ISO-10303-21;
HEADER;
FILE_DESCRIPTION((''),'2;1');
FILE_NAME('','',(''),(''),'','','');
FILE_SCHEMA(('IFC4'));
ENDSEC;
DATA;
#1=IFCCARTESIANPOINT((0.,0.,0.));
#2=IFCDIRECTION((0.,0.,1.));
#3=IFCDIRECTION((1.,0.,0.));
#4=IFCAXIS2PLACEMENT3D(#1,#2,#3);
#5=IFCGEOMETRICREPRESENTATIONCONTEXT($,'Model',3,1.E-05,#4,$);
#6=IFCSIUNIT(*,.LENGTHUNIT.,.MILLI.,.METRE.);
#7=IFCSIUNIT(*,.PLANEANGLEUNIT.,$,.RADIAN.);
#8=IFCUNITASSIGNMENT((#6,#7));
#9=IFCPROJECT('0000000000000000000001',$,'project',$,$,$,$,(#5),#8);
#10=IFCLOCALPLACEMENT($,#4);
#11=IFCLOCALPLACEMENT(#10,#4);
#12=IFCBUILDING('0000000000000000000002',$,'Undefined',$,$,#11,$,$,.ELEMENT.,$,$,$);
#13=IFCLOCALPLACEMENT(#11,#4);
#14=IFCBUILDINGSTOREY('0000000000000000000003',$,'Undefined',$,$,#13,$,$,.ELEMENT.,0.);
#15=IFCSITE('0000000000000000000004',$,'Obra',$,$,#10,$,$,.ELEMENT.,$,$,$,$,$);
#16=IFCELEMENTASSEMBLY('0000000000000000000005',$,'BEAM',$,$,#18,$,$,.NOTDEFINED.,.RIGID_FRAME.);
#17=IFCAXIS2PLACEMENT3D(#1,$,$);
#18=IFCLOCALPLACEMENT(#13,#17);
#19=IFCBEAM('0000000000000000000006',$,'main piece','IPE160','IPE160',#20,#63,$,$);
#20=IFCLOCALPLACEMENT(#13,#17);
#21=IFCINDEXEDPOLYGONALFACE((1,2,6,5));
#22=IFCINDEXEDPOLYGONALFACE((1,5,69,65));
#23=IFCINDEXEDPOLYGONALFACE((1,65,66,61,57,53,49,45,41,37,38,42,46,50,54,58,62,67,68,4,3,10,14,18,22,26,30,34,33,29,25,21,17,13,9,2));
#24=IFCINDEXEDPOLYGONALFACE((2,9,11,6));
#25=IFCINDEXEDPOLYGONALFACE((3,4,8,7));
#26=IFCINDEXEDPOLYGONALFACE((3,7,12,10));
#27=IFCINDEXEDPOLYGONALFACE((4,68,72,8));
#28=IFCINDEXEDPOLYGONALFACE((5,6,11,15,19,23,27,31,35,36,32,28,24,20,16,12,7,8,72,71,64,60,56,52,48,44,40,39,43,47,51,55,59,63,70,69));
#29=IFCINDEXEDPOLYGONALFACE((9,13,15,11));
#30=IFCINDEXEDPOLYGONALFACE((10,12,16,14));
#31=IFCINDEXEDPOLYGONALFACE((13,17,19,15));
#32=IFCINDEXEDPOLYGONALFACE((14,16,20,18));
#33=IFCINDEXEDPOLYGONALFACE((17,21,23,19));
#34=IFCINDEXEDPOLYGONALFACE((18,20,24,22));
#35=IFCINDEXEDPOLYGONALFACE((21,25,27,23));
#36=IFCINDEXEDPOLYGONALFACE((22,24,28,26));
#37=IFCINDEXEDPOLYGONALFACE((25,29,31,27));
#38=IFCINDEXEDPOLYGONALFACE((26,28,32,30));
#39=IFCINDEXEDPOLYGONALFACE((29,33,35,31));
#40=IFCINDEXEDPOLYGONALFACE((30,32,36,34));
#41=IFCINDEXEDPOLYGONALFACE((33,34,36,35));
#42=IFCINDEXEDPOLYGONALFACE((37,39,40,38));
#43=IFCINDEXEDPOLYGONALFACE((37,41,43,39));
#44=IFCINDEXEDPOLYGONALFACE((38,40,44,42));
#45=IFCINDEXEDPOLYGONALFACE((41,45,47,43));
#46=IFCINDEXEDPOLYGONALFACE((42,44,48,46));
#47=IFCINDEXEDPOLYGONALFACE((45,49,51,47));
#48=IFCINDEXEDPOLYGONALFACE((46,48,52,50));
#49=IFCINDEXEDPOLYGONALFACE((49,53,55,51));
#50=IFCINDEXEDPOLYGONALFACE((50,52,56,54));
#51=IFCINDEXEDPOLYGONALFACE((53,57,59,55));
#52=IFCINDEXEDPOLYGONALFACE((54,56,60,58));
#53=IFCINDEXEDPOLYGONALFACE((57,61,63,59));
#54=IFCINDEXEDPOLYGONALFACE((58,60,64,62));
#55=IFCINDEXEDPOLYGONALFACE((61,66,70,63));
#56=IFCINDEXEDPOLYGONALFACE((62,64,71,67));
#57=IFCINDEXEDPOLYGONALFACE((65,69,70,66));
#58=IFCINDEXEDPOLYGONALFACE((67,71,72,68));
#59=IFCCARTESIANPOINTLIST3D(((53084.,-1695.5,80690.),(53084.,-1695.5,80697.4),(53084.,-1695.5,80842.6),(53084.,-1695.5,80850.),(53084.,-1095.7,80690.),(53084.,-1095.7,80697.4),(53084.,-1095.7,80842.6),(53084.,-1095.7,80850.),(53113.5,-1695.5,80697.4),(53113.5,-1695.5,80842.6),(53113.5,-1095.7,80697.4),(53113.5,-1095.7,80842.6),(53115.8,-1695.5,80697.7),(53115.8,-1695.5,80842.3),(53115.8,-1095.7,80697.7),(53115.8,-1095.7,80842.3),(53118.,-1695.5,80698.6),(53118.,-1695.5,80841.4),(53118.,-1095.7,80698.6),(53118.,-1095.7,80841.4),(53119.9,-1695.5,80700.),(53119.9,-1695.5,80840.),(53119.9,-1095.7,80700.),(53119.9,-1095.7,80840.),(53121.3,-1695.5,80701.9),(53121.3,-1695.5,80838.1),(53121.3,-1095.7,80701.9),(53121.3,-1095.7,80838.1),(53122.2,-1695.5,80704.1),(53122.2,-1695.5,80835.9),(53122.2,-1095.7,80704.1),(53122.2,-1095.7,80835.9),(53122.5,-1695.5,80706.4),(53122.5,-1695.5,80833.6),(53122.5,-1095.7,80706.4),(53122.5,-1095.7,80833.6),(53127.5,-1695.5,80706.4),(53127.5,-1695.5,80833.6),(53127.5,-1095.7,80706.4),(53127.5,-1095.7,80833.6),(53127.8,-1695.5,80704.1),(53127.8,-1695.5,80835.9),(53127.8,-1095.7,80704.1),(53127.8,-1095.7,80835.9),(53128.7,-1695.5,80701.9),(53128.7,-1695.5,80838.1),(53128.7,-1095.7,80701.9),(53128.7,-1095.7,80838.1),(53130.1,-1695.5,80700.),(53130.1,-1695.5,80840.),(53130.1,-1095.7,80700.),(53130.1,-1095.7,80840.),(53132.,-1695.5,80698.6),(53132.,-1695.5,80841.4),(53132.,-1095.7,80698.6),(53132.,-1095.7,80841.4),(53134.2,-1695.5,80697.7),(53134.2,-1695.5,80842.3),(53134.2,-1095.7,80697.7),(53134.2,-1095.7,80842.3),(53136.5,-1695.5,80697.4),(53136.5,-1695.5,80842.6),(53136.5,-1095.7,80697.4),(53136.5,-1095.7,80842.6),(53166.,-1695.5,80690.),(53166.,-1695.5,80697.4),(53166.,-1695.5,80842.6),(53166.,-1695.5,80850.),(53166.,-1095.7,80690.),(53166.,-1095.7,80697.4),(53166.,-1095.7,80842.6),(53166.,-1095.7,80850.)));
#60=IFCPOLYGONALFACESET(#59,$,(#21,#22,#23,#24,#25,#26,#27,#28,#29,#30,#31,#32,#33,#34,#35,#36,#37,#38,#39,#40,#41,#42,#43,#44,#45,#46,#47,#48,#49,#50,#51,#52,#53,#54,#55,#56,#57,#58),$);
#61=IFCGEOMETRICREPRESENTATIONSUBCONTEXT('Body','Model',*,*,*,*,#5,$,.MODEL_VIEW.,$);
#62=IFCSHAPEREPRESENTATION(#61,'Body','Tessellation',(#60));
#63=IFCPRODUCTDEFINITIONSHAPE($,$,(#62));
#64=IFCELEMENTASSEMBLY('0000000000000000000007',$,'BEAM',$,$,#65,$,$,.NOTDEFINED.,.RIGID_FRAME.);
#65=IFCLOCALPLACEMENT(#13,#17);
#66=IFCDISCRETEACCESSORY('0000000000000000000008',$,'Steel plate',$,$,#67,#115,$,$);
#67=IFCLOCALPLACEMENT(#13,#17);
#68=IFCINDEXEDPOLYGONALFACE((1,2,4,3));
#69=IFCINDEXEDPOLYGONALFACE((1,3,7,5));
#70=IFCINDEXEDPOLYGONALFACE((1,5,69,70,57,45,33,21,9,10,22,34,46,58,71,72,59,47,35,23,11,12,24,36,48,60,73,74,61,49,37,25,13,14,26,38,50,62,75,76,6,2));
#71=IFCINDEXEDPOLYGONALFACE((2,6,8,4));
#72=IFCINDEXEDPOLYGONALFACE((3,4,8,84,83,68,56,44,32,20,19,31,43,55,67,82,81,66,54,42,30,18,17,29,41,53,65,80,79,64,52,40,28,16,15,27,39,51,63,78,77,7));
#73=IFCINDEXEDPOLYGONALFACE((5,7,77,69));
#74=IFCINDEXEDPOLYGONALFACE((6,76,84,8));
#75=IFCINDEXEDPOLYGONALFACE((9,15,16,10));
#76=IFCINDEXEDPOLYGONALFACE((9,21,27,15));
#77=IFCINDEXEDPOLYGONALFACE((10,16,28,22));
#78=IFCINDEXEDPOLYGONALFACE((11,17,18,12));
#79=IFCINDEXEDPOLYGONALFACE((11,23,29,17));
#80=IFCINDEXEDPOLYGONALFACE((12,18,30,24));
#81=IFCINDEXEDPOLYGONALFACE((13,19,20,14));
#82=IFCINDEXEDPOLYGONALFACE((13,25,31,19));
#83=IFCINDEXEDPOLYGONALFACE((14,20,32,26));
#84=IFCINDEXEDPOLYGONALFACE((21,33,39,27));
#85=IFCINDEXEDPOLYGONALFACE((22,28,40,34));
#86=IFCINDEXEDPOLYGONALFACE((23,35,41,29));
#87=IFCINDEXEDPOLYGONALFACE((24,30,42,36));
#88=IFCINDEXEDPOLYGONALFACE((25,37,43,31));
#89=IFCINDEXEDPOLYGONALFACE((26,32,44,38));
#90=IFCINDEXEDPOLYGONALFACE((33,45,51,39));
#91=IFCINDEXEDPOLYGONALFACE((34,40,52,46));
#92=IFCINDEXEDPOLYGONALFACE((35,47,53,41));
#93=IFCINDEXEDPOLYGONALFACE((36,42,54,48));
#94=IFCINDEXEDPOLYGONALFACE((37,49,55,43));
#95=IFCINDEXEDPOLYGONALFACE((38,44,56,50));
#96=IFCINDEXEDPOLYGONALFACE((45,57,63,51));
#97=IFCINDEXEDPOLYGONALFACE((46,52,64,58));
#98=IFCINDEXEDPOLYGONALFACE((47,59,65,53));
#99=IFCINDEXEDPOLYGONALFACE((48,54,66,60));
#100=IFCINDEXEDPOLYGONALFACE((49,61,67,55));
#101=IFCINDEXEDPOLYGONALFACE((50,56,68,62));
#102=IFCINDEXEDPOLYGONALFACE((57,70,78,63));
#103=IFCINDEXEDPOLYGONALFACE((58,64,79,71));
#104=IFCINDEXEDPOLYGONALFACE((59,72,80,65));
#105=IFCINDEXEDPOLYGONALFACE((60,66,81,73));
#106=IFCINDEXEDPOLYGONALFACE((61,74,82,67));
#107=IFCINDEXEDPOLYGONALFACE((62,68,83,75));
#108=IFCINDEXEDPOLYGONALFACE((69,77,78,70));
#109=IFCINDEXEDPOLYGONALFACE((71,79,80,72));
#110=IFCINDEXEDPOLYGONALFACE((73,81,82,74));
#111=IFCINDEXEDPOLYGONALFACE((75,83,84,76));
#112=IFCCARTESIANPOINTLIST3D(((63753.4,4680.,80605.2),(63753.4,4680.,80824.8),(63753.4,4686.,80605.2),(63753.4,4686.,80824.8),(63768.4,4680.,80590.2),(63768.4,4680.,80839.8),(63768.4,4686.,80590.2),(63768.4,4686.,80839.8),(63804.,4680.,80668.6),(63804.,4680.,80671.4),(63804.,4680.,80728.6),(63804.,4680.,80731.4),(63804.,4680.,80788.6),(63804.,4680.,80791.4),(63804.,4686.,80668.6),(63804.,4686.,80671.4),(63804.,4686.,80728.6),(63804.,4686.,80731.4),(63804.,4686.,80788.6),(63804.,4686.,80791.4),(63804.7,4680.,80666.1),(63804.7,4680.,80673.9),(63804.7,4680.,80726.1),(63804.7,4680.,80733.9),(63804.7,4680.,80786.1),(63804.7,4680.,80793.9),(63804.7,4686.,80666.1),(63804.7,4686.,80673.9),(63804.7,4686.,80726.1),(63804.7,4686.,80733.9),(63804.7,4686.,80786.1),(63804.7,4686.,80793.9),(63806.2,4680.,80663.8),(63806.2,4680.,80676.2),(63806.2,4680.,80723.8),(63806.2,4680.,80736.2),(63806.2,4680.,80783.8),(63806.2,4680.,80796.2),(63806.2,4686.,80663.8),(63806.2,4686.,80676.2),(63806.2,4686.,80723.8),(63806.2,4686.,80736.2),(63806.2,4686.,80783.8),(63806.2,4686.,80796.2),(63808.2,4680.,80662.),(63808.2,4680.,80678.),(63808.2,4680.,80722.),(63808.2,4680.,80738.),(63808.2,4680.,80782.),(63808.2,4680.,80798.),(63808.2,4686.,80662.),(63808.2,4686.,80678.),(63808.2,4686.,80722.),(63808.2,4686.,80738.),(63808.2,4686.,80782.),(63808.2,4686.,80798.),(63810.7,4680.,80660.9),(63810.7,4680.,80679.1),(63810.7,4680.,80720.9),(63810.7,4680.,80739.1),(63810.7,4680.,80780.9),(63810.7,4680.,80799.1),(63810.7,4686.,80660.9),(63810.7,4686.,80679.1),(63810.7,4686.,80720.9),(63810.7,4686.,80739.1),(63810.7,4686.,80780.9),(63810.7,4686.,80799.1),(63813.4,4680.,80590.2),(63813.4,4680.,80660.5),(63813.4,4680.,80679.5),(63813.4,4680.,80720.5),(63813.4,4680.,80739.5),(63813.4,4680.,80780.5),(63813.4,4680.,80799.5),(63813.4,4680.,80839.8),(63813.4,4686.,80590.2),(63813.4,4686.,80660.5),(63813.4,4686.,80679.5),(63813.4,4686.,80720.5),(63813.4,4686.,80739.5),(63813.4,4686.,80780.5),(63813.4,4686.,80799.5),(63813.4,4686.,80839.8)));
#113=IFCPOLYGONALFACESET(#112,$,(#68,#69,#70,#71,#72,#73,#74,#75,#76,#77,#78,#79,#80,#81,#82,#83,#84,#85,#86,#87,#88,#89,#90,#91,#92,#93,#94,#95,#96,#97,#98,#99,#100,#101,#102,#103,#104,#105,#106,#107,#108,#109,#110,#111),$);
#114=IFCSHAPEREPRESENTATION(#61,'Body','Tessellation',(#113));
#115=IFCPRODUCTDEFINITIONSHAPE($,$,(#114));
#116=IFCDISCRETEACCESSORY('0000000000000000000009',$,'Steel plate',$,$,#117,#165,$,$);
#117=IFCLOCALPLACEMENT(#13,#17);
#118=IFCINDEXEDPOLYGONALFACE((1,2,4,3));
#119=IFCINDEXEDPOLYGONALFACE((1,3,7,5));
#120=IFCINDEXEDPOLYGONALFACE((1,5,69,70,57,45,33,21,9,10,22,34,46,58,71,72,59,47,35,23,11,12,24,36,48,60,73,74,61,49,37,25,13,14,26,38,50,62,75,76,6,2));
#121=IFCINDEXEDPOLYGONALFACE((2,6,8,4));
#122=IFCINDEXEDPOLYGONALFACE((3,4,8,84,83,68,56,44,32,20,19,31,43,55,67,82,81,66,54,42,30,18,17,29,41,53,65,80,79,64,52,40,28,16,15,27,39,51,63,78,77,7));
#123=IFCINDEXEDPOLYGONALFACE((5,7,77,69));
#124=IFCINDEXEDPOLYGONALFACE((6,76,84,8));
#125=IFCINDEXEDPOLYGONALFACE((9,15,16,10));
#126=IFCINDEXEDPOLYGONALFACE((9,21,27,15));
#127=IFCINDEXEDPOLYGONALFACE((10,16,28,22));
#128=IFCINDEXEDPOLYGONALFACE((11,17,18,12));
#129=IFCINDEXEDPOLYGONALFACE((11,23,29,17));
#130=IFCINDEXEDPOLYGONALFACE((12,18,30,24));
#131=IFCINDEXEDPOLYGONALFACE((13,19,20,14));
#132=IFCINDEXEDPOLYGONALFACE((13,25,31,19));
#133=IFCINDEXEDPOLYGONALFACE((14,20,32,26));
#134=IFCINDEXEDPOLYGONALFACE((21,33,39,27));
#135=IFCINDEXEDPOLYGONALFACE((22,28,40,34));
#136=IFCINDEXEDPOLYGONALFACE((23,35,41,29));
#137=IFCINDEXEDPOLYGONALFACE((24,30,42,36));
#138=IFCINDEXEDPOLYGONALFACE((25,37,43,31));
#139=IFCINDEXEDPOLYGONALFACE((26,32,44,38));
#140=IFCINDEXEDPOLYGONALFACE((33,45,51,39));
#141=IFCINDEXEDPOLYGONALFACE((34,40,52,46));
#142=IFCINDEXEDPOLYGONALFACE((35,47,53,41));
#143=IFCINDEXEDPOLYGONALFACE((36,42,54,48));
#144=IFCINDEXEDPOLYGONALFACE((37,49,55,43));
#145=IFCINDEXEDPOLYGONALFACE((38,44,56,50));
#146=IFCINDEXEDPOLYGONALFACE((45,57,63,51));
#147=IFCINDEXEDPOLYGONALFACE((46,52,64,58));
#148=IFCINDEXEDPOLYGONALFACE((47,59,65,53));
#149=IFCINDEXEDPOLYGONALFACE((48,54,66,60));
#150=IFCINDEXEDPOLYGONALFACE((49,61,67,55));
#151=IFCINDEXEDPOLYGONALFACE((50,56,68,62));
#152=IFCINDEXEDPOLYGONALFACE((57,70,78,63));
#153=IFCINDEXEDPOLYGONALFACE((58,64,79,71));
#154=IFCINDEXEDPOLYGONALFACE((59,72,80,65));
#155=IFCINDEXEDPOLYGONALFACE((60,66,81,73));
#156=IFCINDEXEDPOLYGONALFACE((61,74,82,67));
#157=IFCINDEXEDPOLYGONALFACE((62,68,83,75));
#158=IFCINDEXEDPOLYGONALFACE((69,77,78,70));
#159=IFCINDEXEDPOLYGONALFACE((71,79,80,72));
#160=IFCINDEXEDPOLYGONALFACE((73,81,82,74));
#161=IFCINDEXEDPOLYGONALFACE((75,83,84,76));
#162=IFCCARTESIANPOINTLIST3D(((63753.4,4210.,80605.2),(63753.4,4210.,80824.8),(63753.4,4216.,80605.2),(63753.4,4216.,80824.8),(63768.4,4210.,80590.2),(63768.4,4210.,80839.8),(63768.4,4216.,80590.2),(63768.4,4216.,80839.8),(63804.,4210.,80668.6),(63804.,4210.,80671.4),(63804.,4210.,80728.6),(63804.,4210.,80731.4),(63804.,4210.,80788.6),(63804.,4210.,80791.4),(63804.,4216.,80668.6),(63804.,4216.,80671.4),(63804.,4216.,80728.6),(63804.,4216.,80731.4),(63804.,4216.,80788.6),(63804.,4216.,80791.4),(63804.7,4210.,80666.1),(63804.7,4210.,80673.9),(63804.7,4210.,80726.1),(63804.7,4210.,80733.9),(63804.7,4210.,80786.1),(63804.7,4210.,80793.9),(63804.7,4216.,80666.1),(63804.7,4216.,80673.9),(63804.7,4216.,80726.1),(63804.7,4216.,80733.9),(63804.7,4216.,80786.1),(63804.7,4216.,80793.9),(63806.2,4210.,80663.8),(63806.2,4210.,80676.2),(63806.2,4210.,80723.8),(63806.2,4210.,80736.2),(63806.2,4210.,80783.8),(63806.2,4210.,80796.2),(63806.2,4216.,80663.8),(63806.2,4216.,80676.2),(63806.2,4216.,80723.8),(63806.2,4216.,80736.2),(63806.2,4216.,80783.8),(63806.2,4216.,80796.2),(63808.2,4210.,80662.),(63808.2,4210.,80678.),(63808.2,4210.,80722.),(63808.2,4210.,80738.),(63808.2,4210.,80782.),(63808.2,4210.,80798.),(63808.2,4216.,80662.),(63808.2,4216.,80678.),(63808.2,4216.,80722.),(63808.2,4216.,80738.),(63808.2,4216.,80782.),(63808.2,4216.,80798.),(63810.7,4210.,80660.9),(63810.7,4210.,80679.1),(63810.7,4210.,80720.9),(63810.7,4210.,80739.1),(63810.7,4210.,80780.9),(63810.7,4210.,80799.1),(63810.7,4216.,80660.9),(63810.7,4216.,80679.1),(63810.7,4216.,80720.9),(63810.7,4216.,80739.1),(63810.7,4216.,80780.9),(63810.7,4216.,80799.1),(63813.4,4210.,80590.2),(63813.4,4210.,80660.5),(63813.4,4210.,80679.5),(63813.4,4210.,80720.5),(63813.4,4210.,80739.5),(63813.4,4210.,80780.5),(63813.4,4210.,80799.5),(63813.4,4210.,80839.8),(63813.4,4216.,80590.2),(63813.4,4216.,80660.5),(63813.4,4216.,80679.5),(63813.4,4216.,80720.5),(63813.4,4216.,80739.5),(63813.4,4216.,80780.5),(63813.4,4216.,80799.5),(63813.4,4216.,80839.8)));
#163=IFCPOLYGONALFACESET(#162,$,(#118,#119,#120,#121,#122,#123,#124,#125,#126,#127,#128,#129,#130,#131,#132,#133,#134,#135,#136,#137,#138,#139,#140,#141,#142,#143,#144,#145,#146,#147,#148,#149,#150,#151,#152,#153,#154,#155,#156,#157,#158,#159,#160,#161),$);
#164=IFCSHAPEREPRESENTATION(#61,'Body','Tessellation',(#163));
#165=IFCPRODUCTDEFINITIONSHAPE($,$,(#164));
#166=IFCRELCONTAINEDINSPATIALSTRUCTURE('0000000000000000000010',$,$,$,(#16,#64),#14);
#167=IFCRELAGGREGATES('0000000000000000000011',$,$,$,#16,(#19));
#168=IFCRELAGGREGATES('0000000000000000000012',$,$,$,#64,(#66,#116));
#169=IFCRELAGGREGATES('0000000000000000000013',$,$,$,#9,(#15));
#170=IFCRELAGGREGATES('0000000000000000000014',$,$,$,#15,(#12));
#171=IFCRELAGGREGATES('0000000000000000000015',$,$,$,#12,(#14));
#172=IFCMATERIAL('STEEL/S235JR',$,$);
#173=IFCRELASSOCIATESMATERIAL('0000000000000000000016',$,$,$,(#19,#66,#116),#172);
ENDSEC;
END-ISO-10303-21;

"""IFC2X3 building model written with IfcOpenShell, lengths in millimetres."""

from ifc_helpers import new_model, si_unit, frame, origin_with_axes, origin_2d_with_axis, place, context, subcontext, project, spatial, polyline, circle, i_section, outline, extrude, source, transform, mapped, material, element, aggregate, save


model = new_model("IFC2X3")

# Units and contexts
model_context = context("Model", 3, precision=1e-05, world=origin_with_axes())
body_context = subcontext(model_context, "Body", "Model", "MODEL_VIEW")
ifc_project = project(units=[si_unit("LENGTHUNIT", "METRE", prefix="MILLI"), si_unit("PLANEANGLEUNIT", "RADIAN")], contexts=[model_context])

# Site, building, storey
site_placement = place(None, origin_with_axes())
site = spatial("IfcSite", under=ifc_project, at=site_placement, Name="Obra", CompositionType="ELEMENT")
building_placement = place(site_placement, origin_with_axes())
building = spatial("IfcBuilding", under=site, at=building_placement, Name="Undefined", CompositionType="ELEMENT")
storey_placement = place(building_placement, origin_with_axes())
storey = spatial("IfcBuildingStorey", under=building, at=storey_placement, Name="Undefined", CompositionType="ELEMENT", Elevation=0.0)

# Element assembly, beam
ifc_material_1 = material(Name="STEEL/S235JR")
assembly_1_placement = place(storey_placement, origin_with_axes())
assembly_1 = element("IfcElementAssembly", 1, at=assembly_1_placement, inside=storey, Name="BEAM", AssemblyPlace="NOTDEFINED", PredefinedType="RIGID_FRAME")
beam_1_placement = place(assembly_1_placement, frame((53125.0, -1095.7, 80770.0), z_axis=(0.0, 0.0, 1.0), x_axis=(0.0, -1.0, 0.0)))
beam_1 = element("IfcBeam", 2, at=beam_1_placement, material=ifc_material_1, Name="main piece", Description="IPE160", ObjectType="IPE160", context=body_context, shape_type="SweptSolid", body=[
    extrude(i_section(OverallWidth=82.0, OverallDepth=160.0, WebThickness=5.0, FlangeThickness=7.4, FilletRadius=9.0, at=origin_2d_with_axis()), frame((599.8, 0.0, 0.0), z_axis=(-1.0, 0.0, 0.0), x_axis=(0.0, -1.0, 0.0)), (0.0, 0.0, 1.0), 599.8),
])
aggregate(assembly_1, [beam_1])

# Element assembly
assembly_2_placement = place(storey_placement, origin_with_axes())
assembly_2 = element("IfcElementAssembly", 3, at=assembly_2_placement, inside=storey, Name="BEAM", AssemblyPlace="NOTDEFINED", PredefinedType="RIGID_FRAME")

# Discrete accessories, openings
discrete_accessory_1_placement = place(assembly_2_placement, frame((63813.4, 4683.0, 80590.2), z_axis=(0.0, 1.0, 0.0), x_axis=(-1.0, 0.0, 0.0)))
discrete_accessory_1 = element("IfcDiscreteAccessory", 4, at=discrete_accessory_1_placement, material=ifc_material_1, Name="Steel plate", context=body_context, shape_type="SweptSolid", body=[
    extrude(outline(polyline([(0.0, 0.0), (45.0, 0.0), (60.0, 15.0), (60.0, 234.6), (45.0, 249.6), (0.0, 249.6), (0.0, 0.0)])), frame((0.0, 0.0, -3.0), z_axis=(0.0, 0.0, 1.0), x_axis=(1.0, 0.0, 0.0)), (0.0, 0.0, 1.0), 6.0),
])
shared_shape_1 = source(origin_with_axes(), body_context, "Body", "SweptSolid", [
    extrude(circle(Radius=9.5, at=origin_2d_with_axis()), frame((0.0, -9.2, 0.0), z_axis=(0.0, 1.0, 0.0), x_axis=(1.0, 0.0, 0.0)), (0.0, 0.0, 1.0), 6.2),
])
opening_1_placement = place(assembly_2_placement, frame((63763.4, 4689.1, 80850.0), z_axis=(1.0, 0.0, 0.0), x_axis=(0.0, 0.0, -1.0)))
element("IfcOpeningElement", 5, at=opening_1_placement, cuts=discrete_accessory_1, ObjectType="Opening", context=body_context, shape_type="MappedRepresentation", body=[
    mapped(shared_shape_1, transform((60.0, 0.0, 50.0))),
    mapped(shared_shape_1, transform((120.0, 0.0, 50.0))),
    mapped(shared_shape_1, transform((180.0, 0.0, 50.0))),
])
discrete_accessory_2_placement = place(assembly_2_placement, frame((63813.4, 4213.0, 80590.2), z_axis=(0.0, 1.0, 0.0), x_axis=(-1.0, 0.0, 0.0)))
discrete_accessory_2 = element("IfcDiscreteAccessory", 6, at=discrete_accessory_2_placement, material=ifc_material_1, Name="Steel plate", context=body_context, shape_type="SweptSolid", body=[
    extrude(outline(polyline([(0.0, 0.0), (45.0, 0.0), (60.0, 15.0), (60.0, 234.6), (45.0, 249.6), (0.0, 249.6), (0.0, 0.0)])), frame((0.0, 0.0, -3.0), z_axis=(0.0, 0.0, 1.0), x_axis=(1.0, 0.0, 0.0)), (0.0, 0.0, 1.0), 6.0),
])
opening_2_placement = place(assembly_2_placement, frame((63763.4, 4219.1, 80850.0), z_axis=(1.0, 0.0, 0.0), x_axis=(0.0, 0.0, -1.0)))
element("IfcOpeningElement", 7, at=opening_2_placement, cuts=discrete_accessory_2, ObjectType="Opening", context=body_context, shape_type="MappedRepresentation", body=[
    mapped(shared_shape_1, transform((60.0, 0.0, 50.0))),
    mapped(shared_shape_1, transform((120.0, 0.0, 50.0))),
    mapped(shared_shape_1, transform((180.0, 0.0, 50.0))),
])
aggregate(assembly_2, [discrete_accessory_1, discrete_accessory_2])

save(model, "model.ifc")
